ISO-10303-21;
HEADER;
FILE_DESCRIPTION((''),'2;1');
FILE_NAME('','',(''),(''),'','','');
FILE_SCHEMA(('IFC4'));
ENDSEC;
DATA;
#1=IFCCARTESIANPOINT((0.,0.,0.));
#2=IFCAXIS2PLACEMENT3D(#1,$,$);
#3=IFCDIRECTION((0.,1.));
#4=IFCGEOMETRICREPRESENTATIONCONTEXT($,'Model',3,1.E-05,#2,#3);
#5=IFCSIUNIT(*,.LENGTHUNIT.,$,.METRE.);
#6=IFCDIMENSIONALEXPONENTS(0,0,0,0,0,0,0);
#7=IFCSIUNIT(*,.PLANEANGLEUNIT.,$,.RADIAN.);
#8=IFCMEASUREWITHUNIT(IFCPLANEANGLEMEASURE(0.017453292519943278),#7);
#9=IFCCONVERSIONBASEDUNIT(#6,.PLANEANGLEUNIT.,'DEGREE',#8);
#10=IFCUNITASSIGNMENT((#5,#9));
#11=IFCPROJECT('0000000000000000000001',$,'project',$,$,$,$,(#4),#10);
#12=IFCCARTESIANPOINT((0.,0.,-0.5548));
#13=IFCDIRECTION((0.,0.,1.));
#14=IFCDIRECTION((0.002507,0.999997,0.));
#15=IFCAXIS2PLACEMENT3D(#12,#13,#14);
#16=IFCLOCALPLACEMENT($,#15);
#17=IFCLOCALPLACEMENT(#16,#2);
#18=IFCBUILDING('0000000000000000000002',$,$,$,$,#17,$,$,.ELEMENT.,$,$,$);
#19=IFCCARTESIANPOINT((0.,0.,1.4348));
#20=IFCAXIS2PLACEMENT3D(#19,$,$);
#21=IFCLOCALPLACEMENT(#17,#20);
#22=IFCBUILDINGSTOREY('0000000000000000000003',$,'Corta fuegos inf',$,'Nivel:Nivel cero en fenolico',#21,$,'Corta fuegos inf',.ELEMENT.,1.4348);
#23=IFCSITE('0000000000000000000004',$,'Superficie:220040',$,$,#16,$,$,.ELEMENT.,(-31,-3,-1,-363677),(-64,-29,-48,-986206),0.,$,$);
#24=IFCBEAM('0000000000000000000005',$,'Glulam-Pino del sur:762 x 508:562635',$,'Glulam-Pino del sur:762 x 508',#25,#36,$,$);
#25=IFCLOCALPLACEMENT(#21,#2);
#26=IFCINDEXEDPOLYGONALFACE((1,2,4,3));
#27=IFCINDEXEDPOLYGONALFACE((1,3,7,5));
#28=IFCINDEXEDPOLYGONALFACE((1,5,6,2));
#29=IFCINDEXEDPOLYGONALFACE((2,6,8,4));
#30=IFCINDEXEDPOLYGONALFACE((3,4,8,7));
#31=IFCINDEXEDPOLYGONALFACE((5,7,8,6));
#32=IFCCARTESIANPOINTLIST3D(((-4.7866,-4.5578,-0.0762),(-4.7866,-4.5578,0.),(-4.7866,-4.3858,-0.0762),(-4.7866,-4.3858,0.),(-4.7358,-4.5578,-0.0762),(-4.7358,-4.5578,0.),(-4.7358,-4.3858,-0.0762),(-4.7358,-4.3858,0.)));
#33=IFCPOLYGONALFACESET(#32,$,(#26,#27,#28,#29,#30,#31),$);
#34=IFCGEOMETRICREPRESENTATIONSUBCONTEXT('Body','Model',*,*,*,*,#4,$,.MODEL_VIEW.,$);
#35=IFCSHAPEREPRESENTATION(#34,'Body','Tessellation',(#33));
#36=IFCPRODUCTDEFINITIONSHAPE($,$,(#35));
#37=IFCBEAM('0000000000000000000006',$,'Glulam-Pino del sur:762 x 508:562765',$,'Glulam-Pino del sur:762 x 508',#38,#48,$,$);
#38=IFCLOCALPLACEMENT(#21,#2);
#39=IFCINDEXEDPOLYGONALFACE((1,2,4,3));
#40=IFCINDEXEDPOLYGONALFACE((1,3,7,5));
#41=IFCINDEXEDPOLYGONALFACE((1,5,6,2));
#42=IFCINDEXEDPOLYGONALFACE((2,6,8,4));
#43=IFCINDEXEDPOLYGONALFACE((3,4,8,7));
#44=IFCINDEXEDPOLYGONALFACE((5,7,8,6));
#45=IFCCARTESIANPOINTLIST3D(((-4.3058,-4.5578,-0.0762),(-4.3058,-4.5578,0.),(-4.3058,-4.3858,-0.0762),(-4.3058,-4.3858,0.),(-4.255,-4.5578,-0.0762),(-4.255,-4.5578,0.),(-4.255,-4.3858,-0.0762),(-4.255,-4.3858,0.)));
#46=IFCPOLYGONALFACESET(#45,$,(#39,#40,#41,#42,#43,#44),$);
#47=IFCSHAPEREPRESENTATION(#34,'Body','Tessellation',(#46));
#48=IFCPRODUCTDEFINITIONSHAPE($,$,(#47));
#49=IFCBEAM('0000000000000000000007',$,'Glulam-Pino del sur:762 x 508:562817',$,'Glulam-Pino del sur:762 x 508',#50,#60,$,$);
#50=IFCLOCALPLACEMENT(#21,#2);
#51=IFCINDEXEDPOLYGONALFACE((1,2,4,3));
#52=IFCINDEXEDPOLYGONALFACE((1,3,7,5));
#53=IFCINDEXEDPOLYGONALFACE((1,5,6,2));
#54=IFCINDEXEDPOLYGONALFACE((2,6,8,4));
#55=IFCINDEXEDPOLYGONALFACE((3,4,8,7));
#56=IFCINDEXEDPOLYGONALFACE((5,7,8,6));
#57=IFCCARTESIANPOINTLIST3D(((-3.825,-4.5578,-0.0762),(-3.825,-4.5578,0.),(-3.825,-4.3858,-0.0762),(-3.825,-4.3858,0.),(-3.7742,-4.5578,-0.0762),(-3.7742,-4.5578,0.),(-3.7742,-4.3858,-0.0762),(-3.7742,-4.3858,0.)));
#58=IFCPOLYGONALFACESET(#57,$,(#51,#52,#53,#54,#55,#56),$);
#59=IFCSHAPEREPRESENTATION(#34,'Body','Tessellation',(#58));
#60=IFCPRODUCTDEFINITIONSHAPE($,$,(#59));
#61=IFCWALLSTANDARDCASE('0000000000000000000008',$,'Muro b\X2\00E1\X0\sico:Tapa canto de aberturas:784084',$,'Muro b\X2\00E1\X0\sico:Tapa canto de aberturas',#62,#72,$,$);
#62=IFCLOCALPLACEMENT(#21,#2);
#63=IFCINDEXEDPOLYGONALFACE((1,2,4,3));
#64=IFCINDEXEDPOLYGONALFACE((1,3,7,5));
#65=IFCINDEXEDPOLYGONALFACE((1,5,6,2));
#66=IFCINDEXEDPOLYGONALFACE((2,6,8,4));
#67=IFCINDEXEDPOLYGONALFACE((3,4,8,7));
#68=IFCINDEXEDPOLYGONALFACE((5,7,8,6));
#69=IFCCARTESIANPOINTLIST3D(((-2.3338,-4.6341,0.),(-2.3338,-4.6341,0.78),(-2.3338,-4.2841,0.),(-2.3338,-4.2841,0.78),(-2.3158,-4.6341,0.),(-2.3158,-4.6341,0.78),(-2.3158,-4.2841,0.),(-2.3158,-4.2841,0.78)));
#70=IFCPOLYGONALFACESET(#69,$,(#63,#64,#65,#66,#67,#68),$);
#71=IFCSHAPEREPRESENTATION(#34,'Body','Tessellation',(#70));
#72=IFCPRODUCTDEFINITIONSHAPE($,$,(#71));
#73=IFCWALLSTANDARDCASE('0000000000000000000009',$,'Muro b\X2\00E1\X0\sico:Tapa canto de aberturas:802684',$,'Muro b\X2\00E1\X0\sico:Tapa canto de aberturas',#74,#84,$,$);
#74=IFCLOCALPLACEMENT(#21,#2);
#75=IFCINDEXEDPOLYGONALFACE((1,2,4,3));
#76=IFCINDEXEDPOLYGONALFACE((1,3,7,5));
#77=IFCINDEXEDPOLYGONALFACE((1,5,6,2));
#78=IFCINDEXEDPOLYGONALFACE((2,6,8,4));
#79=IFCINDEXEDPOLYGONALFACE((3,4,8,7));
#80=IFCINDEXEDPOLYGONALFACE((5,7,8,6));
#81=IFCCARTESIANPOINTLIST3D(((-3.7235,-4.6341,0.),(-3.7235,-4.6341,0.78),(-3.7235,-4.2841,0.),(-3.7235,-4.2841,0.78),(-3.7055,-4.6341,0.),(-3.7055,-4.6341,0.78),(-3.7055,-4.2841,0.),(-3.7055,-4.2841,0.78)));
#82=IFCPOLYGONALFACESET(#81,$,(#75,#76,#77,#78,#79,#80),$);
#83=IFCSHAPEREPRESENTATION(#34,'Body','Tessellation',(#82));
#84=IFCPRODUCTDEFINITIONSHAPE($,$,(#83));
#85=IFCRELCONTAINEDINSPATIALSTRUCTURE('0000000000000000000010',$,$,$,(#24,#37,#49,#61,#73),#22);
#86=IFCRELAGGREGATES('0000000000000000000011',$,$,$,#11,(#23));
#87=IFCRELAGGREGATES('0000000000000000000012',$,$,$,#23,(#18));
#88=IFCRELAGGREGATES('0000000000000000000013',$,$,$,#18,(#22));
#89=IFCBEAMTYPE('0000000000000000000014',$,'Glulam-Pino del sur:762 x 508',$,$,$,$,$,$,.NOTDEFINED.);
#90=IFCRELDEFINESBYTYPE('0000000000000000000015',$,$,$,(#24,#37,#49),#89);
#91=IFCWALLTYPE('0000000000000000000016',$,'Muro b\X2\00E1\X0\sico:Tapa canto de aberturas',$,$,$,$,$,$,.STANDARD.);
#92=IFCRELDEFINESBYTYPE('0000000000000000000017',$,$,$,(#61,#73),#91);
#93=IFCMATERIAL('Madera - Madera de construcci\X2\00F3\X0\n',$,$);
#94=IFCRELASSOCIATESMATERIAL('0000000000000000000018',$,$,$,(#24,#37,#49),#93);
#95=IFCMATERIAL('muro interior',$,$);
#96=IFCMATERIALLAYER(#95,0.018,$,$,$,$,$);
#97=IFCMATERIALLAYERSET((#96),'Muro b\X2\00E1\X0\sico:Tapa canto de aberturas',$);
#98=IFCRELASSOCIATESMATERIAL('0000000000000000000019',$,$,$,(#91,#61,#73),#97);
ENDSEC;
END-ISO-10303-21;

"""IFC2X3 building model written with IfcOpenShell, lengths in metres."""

from ifc_helpers import new_model, entity, si_unit, converted_unit, direction, frame, frame_2d, origin, origin_2d_with_axis, place, context, subcontext, project, spatial, rectangle, extrude, clip, halfspace, material, layer, layer_set, layer_usage, type_object, element, save


model = new_model("IFC2X3")

# Units and contexts
model_context = context("Model", 3, precision=1e-05, world=origin(), true_north=direction((0.0, 1.0)))
body_context = subcontext(model_context, "Body", "Model", "MODEL_VIEW")
ifc_project = project(units=[si_unit("LENGTHUNIT", "METRE"), converted_unit("PLANEANGLEUNIT", "DEGREE", entity("IfcPlaneAngleMeasure", 0.017453292519943278), si_unit("PLANEANGLEUNIT", "RADIAN"), dimensions=[0, 0, 0, 0, 0, 0, 0])], contexts=[model_context])

# Site, building, storey
site_placement = place(None, frame((0.0, 0.0, -0.5548), z_axis=(0.0, 0.0, 1.0), x_axis=(0.002507, 0.999997, 0.0)))
site = spatial("IfcSite", under=ifc_project, at=site_placement, Name="Superficie:220040", CompositionType="ELEMENT", RefLatitude=(-31, -3, -1, -363677), RefLongitude=(-64, -29, -48, -986206), RefElevation=0.0)
building_placement = place(site_placement, origin())
building = spatial("IfcBuilding", under=site, at=building_placement, CompositionType="ELEMENT")
storey_placement = place(building_placement, frame((0.0, 0.0, 1.4348)))
storey = spatial("IfcBuildingStorey", under=building, at=storey_placement, Name="Corta fuegos inf", ObjectType="Nivel:Nivel cero en fenolico", LongName="Corta fuegos inf", CompositionType="ELEMENT", Elevation=1.4348)

# Shared definitions
ifc_material_1 = material(Name="Madera - Madera de construcción")

# Beams
beam_type_1 = type_object("IfcBeamType", Name="Glulam-Pino del sur:762 x 508", PredefinedType="NOTDEFINED")
beam_1_placement = place(storey_placement, frame((-4.7612, -4.5579, 0.0), z_axis=(0.0, 0.0, 1.0), x_axis=(0.0, 1.0, 0.0)))
element("IfcBeam", 1, at=beam_1_placement, inside=storey, type_object=beam_type_1, material=ifc_material_1, Name="Glulam-Pino del sur:762 x 508:562635", ObjectType="Glulam-Pino del sur:762 x 508", context=body_context, shape_type="SweptSolid", body=[
    extrude(rectangle(XDim=0.0762, YDim=0.0508, at=origin_2d_with_axis()), frame((0.0001, 0.0, -0.0381), z_axis=(1.0, 0.0, 0.0), x_axis=(0.0, 0.0, -1.0)), (0.0, 0.0, 1.0), 0.172),
])
beam_2_placement = place(storey_placement, frame((-4.2804, -4.5579, 0.0), z_axis=(0.0, 0.0, 1.0), x_axis=(0.0, 1.0, 0.0)))
element("IfcBeam", 2, at=beam_2_placement, inside=storey, type_object=beam_type_1, material=ifc_material_1, Name="Glulam-Pino del sur:762 x 508:562765", ObjectType="Glulam-Pino del sur:762 x 508", context=body_context, shape_type="SweptSolid", body=[
    extrude(rectangle(XDim=0.0762, YDim=0.0508, at=origin_2d_with_axis()), frame((0.0001, 0.0, -0.0381), z_axis=(1.0, 0.0, 0.0), x_axis=(0.0, 0.0, -1.0)), (0.0, 0.0, 1.0), 0.172),
])
beam_3_placement = place(storey_placement, frame((-3.7996, -4.5579, 0.0), z_axis=(0.0, 0.0, 1.0), x_axis=(0.0, 1.0, 0.0)))
element("IfcBeam", 3, at=beam_3_placement, inside=storey, type_object=beam_type_1, material=ifc_material_1, Name="Glulam-Pino del sur:762 x 508:562817", ObjectType="Glulam-Pino del sur:762 x 508", context=body_context, shape_type="SweptSolid", body=[
    extrude(rectangle(XDim=0.0762, YDim=0.0508, at=origin_2d_with_axis()), frame((0.0001, 0.0, -0.0381), z_axis=(1.0, 0.0, 0.0), x_axis=(0.0, 0.0, -1.0)), (0.0, 0.0, 1.0), 0.172),
])

# Walls
ifc_material_2 = material(Name="muro interior")
ifc_layer = layer(ifc_material_2, 0.018)
ifc_layer_set = layer_set([ifc_layer], Name="Muro básico:Tapa canto de aberturas")
ifc_layer_usage_1 = layer_usage(ifc_layer_set, "AXIS2", "POSITIVE", -0.009)
wall_type = type_object("IfcWallType", Name="Muro básico:Tapa canto de aberturas", PredefinedType="STANDARD", material=ifc_layer_set)
wall_1_placement = place(storey_placement, frame((-2.3248, -4.6341, 0.0), z_axis=(0.0, 0.0, 1.0), x_axis=(0.0, 1.0, 0.0)))
element("IfcWallStandardCase", 4, at=wall_1_placement, inside=storey, type_object=wall_type, material=ifc_layer_usage_1, Name="Muro básico:Tapa canto de aberturas:784084", ObjectType="Muro básico:Tapa canto de aberturas", context=body_context, shape_type="Clipping", body=[
    clip(extrude(rectangle(XDim=0.35, YDim=0.018, at=frame_2d((0.175, 0.0), x_axis=(-1.0, 0.0))), origin(), (0.0, 0.0, 1.0), 0.78), halfspace(frame((0.0, 0.0, -0.5548)), True)),
])
ifc_layer_usage_2 = layer_usage(ifc_layer_set, "AXIS2", "NEGATIVE", 0.009)
wall_2_placement = place(storey_placement, frame((-3.7145, -4.6341, 0.0), z_axis=(0.0, 0.0, 1.0), x_axis=(0.0, 1.0, 0.0)))
element("IfcWallStandardCase", 5, at=wall_2_placement, inside=storey, type_object=wall_type, material=ifc_layer_usage_2, Name="Muro básico:Tapa canto de aberturas:802684", ObjectType="Muro básico:Tapa canto de aberturas", context=body_context, shape_type="Clipping", body=[
    clip(extrude(rectangle(XDim=0.35, YDim=0.018, at=frame_2d((0.175, 0.0), x_axis=(-1.0, 0.0))), origin(), (0.0, 0.0, 1.0), 0.78), halfspace(frame((0.0, 0.0, -0.5548)), True)),
])

save(model, "model.ifc")
